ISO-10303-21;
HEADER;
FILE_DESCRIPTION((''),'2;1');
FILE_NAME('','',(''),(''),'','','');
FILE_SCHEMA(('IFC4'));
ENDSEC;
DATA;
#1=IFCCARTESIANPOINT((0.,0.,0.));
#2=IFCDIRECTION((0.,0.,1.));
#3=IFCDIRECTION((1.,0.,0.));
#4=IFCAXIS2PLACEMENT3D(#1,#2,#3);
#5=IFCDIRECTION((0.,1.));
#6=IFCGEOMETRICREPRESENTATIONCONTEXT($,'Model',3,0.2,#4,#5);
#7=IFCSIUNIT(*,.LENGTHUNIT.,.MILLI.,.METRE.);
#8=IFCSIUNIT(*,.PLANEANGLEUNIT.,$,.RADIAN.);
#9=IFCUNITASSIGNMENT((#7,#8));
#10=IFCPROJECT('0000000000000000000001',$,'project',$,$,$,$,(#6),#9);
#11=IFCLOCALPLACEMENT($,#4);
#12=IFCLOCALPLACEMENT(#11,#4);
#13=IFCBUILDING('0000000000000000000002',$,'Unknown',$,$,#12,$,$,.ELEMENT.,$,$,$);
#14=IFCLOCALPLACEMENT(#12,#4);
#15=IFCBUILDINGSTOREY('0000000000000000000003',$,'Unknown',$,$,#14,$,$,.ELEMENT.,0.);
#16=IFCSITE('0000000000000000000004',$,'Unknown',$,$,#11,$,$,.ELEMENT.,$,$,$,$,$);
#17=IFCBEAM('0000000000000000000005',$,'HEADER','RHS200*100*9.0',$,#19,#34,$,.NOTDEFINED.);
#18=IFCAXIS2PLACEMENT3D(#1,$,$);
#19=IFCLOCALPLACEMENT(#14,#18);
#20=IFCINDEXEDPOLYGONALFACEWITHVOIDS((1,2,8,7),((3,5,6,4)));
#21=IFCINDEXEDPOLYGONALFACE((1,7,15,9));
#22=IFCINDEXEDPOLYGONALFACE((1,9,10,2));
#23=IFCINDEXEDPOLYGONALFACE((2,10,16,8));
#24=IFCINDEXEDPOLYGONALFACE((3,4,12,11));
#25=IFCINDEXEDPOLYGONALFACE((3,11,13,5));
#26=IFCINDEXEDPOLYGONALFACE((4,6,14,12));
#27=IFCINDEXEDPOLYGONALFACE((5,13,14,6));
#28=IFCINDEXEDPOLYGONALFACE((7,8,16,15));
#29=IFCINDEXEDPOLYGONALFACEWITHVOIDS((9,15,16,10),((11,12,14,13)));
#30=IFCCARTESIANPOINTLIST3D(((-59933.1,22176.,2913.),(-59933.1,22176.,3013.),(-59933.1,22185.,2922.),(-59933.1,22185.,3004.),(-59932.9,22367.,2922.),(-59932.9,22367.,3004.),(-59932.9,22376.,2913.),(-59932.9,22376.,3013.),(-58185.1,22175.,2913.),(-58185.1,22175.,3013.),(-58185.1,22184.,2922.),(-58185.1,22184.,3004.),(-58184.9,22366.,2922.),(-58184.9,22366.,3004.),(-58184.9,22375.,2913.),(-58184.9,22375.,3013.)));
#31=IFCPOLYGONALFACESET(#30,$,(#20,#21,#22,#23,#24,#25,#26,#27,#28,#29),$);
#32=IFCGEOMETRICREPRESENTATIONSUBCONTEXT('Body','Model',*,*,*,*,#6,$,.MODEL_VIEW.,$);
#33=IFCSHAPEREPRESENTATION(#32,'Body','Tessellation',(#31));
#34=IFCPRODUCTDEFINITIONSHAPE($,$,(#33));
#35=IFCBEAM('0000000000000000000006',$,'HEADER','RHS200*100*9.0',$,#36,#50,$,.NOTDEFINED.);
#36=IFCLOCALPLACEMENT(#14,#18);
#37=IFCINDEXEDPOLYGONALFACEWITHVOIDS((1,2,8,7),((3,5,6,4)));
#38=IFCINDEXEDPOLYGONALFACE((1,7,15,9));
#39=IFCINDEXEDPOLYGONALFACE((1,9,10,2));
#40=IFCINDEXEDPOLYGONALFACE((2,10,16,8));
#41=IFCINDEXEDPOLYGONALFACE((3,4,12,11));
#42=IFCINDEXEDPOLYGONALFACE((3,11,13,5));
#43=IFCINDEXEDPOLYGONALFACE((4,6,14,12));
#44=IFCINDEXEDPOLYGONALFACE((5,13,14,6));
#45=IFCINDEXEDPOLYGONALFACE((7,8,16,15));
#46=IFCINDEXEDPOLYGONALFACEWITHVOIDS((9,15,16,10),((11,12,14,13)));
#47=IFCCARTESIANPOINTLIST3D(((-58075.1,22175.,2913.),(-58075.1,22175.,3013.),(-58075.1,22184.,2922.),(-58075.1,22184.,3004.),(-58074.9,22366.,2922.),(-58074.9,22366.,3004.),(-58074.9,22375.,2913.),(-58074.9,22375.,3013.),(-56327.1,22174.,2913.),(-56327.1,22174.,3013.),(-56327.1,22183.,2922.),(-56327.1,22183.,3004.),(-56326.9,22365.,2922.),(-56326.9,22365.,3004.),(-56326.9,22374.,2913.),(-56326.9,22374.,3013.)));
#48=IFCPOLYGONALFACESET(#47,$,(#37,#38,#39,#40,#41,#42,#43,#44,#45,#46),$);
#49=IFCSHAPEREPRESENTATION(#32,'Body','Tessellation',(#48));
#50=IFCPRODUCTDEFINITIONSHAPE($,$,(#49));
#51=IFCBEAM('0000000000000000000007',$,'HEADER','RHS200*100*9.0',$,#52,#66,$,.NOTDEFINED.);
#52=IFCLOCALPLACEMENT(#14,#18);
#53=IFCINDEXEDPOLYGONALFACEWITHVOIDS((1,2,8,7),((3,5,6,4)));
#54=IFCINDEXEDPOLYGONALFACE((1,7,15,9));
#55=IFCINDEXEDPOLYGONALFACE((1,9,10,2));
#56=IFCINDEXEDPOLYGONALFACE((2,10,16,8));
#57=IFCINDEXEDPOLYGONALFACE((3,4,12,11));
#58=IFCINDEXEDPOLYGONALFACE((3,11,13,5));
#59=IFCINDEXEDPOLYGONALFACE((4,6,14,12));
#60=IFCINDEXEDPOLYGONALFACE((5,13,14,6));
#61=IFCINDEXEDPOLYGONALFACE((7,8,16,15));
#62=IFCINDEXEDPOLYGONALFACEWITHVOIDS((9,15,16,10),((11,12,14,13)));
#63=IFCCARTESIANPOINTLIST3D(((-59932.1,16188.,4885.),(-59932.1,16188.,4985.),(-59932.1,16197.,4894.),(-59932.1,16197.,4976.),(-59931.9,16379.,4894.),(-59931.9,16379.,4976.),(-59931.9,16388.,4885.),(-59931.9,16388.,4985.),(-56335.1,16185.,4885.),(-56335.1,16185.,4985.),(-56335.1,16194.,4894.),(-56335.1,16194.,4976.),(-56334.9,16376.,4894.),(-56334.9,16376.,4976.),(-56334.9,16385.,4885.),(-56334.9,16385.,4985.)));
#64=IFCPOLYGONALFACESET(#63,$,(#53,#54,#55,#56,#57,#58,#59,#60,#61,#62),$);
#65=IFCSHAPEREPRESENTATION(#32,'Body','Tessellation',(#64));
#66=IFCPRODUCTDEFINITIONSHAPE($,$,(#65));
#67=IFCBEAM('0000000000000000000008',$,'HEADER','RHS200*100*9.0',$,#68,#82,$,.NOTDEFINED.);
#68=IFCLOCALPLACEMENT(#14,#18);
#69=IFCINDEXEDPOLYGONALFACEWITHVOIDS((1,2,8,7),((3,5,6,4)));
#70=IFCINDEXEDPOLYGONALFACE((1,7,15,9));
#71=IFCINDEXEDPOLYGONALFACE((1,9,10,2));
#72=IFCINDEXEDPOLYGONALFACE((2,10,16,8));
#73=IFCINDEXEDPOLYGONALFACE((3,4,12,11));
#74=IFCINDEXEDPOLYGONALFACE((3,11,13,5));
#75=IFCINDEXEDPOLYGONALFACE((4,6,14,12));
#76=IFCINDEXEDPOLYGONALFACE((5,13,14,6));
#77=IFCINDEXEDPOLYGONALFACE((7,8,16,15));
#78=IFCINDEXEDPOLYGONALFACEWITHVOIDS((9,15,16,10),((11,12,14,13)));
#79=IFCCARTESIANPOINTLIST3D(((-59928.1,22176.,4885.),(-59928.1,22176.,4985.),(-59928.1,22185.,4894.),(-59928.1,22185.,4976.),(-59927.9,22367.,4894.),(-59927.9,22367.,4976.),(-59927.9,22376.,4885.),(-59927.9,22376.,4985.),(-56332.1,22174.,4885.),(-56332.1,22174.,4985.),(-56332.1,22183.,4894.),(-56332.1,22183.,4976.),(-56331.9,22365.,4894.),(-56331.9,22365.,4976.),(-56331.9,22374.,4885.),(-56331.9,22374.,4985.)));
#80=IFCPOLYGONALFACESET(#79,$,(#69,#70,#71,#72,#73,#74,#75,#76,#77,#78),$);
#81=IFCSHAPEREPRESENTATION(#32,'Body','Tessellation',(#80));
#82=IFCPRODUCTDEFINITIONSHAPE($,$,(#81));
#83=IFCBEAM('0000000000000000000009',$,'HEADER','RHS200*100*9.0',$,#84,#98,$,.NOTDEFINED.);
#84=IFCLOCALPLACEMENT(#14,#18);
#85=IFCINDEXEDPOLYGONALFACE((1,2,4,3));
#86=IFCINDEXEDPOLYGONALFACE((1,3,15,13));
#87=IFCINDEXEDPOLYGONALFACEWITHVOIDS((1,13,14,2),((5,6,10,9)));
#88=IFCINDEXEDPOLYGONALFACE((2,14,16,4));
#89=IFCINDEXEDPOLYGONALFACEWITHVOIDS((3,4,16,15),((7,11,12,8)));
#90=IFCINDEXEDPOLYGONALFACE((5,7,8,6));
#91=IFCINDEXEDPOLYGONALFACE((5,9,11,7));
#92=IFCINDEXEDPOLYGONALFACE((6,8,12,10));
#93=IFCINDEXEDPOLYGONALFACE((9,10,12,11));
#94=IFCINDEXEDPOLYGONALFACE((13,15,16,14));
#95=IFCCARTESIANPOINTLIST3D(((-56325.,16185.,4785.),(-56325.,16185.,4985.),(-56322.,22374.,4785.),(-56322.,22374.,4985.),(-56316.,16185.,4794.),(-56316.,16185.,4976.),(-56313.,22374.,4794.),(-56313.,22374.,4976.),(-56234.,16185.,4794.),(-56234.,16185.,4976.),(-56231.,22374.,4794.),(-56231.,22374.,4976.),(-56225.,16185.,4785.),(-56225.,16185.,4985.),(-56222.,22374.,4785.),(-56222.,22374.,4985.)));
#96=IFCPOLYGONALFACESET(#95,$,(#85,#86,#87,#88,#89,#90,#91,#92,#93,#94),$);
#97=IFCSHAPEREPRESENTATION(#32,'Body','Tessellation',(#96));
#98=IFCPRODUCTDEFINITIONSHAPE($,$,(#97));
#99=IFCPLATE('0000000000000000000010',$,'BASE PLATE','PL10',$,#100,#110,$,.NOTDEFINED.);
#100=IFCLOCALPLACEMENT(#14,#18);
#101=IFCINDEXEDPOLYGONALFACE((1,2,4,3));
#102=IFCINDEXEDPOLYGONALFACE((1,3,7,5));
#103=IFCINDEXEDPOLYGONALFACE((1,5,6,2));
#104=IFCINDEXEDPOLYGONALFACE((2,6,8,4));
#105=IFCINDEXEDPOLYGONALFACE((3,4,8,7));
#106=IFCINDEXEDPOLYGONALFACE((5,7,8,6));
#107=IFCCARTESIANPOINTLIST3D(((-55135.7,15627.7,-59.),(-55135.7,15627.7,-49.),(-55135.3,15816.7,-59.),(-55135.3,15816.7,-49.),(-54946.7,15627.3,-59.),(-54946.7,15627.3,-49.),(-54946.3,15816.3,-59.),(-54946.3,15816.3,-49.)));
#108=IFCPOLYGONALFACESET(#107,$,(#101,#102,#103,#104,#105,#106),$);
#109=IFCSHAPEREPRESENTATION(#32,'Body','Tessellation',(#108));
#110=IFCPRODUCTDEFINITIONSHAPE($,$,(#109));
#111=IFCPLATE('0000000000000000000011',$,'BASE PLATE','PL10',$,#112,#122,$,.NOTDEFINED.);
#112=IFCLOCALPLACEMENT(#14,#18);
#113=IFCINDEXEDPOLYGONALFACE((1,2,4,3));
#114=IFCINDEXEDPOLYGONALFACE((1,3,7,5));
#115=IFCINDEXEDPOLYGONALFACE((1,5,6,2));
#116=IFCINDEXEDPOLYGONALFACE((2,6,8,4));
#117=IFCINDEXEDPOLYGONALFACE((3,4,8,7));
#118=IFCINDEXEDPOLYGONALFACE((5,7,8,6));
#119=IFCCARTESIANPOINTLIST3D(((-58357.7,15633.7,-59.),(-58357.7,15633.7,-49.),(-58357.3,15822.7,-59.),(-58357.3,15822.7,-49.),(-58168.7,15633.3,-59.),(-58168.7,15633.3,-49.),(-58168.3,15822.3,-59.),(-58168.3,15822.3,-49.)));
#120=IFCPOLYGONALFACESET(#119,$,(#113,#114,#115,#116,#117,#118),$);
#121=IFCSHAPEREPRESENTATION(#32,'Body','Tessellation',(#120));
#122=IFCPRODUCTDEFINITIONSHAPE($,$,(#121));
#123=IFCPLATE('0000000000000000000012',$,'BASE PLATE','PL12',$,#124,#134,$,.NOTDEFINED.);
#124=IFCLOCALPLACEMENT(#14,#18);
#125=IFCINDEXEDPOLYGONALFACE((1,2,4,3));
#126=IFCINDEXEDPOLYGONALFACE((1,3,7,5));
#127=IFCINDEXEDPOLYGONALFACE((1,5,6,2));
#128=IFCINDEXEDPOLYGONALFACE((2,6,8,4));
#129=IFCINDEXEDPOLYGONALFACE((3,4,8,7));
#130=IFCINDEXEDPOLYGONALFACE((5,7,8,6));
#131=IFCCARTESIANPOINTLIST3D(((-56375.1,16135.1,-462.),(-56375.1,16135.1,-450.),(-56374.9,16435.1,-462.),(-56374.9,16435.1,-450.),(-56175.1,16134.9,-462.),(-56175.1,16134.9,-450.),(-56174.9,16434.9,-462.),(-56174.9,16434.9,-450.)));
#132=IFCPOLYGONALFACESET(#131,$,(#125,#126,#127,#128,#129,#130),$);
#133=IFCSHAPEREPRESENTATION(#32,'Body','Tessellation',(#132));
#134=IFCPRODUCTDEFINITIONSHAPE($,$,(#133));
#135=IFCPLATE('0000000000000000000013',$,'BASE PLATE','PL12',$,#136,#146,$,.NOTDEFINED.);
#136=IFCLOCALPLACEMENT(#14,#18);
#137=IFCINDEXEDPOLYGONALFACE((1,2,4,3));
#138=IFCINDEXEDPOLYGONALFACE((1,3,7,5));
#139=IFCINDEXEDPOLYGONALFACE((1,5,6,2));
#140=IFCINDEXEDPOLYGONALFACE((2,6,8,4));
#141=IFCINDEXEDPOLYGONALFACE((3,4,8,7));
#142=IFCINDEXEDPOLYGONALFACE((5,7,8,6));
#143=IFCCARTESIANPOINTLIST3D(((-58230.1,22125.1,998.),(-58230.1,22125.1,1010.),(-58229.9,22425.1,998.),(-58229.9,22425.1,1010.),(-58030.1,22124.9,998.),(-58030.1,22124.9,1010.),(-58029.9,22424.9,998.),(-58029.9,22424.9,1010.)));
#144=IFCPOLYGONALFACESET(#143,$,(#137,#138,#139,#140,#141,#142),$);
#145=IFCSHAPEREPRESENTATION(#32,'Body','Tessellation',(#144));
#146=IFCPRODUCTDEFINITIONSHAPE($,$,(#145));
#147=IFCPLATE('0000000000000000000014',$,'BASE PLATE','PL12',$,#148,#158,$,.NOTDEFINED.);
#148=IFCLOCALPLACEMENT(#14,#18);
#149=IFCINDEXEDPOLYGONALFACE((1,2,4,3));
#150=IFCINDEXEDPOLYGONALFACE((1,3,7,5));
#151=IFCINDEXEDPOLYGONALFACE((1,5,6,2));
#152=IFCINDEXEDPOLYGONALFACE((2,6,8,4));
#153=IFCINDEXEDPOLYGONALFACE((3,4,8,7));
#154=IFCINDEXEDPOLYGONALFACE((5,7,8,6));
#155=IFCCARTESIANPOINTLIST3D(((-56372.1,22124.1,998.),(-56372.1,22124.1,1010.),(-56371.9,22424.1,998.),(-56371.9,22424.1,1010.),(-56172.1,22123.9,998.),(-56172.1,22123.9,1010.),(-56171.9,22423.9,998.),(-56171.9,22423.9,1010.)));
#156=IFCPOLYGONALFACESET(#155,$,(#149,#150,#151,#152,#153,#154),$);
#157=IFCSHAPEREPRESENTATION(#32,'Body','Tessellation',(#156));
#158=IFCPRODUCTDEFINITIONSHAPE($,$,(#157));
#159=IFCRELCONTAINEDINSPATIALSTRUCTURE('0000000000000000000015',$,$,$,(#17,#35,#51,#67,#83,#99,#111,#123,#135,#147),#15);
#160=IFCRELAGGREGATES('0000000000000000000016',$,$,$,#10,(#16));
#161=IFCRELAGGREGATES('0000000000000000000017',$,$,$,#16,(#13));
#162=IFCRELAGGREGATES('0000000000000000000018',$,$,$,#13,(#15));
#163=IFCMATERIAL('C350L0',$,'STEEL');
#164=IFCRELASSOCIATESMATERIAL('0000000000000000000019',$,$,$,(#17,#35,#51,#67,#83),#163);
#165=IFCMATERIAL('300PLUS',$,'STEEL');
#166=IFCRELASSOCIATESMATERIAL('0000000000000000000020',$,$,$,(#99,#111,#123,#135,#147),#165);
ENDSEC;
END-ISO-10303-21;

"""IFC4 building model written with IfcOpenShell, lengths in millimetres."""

from ifc_helpers import new_model, si_unit, direction, frame, origin_with_axes, place, context, subcontext, project, spatial, line, indexed_curve, outline, extrude, material, element, save


model = new_model("IFC4")

# Units and contexts
model_context = context("Model", 3, precision=0.2, world=origin_with_axes(), true_north=direction((0.0, 1.0)))
body_context = subcontext(model_context, "Body", "Model", "MODEL_VIEW")
ifc_project = project(units=[si_unit("LENGTHUNIT", "METRE", prefix="MILLI"), si_unit("PLANEANGLEUNIT", "RADIAN")], contexts=[model_context])

# Site, building, storey
site_placement = place(None, origin_with_axes())
site = spatial("IfcSite", under=ifc_project, at=site_placement, Name="Unknown", CompositionType="ELEMENT")
building_placement = place(site_placement, origin_with_axes())
building = spatial("IfcBuilding", under=site, at=building_placement, Name="Unknown", CompositionType="ELEMENT")
storey_placement = place(building_placement, origin_with_axes())
storey = spatial("IfcBuildingStorey", under=building, at=storey_placement, Name="Unknown", CompositionType="ELEMENT", Elevation=0.0)

# Shared definitions
ifc_material_1 = material(Name="C350L0", Category="STEEL")

# Beams
for number, where, z_axis, x_axis, name in (
    (1, (-58185.0, 22275.0, 2963.0), (0.0, 0.0, 1.0), (-1.0, 0.000572, 0.0), "HEADER"),
    (2, (-56327.0, 22274.0, 2963.0), (0.0, 0.0, 1.0), (-1.0, 0.000572, 0.0), "HEADER"),
):
    element("IfcBeam", number, at=place(storey_placement, frame(where, z_axis=z_axis, x_axis=x_axis)), inside=storey, material=ifc_material_1, Name=name, Description="RHS200*100*9.0", PredefinedType="NOTDEFINED", context=body_context, shape_type="SolidModel", body=[
        extrude(outline(indexed_curve([(-50.0, -100.0), (50.0, -100.0), (50.0, 100.0), (-50.0, 100.0)], segments=[line(1, 2, 3, 4, 1)]), holes=[indexed_curve([(-41.0, -91.0), (-41.0, 91.0), (41.0, 91.0), (41.0, -91.0)], segments=[line(1, 2, 3, 4, 1)])]), frame((0.0, 0.0, 0.0), z_axis=(-1.0, 0.0, 0.0), x_axis=(0.0, 0.0, 1.0)), (0.0, 0.0, -1.0), 1748.0),
    ])
beam_1_placement = place(storey_placement, frame((-56335.0, 16285.0, 4935.0), z_axis=(0.0, 0.0, 1.0), x_axis=(-1.0, 0.000834, 0.0)))
element("IfcBeam", 3, at=beam_1_placement, inside=storey, material=ifc_material_1, Name="HEADER", Description="RHS200*100*9.0", PredefinedType="NOTDEFINED", context=body_context, shape_type="SolidModel", body=[
    extrude(outline(indexed_curve([(-50.0, -100.0), (50.0, -100.0), (50.0, 100.0), (-50.0, 100.0)], segments=[line(1, 2, 3, 4, 1)]), holes=[indexed_curve([(-41.0, -91.0), (-41.0, 91.0), (41.0, 91.0), (41.0, -91.0)], segments=[line(1, 2, 3, 4, 1)])]), frame((0.0, 0.0, 0.0), z_axis=(-1.0, 0.0, 0.0), x_axis=(0.0, 0.0, 1.0)), (0.0, 0.0, -1.0), 3597.0),
])
beam_2_placement = place(storey_placement, frame((-56332.0, 22274.0, 4935.0), z_axis=(0.0, 0.0, 1.0), x_axis=(-1.0, 0.000556, 0.0)))
element("IfcBeam", 4, at=beam_2_placement, inside=storey, material=ifc_material_1, Name="HEADER", Description="RHS200*100*9.0", PredefinedType="NOTDEFINED", context=body_context, shape_type="SolidModel", body=[
    extrude(outline(indexed_curve([(-50.0, -100.0), (50.0, -100.0), (50.0, 100.0), (-50.0, 100.0)], segments=[line(1, 2, 3, 4, 1)]), holes=[indexed_curve([(-41.0, -91.0), (-41.0, 91.0), (41.0, 91.0), (41.0, -91.0)], segments=[line(1, 2, 3, 4, 1)])]), frame((0.0, 0.0, 0.0), z_axis=(-1.0, 0.0, 0.0), x_axis=(0.0, 0.0, 1.0)), (0.0, 0.0, -1.0), 3596.0),
])
beam_3_placement = place(storey_placement, frame((-56275.0, 16185.0, 4885.0), z_axis=(1.0, -0.000485, 0.0), x_axis=(0.000485, 1.0, 0.0)))
element("IfcBeam", 5, at=beam_3_placement, inside=storey, material=ifc_material_1, Name="HEADER", Description="RHS200*100*9.0", PredefinedType="NOTDEFINED", context=body_context, shape_type="SolidModel", body=[
    extrude(outline(indexed_curve([(-50.0, -100.0), (50.0, -100.0), (50.0, 100.0), (-50.0, 100.0)], segments=[line(1, 2, 3, 4, 1)]), holes=[indexed_curve([(-41.0, -91.0), (-41.0, 91.0), (41.0, 91.0), (41.0, -91.0)], segments=[line(1, 2, 3, 4, 1)])]), frame((0.0, 0.0, 0.0), z_axis=(-1.0, 0.0, 0.0), x_axis=(0.0, 0.0, 1.0)), (0.0, 0.0, -1.0), 6189.0),
])

# Plates
ifc_material_2 = material(Name="300PLUS", Category="STEEL")
for number, where, z_axis, x_axis, name in (
    (6, (-55135.7, 15627.7, -54.0), (0.0, 0.0, 1.0), (0.999998, -0.002116, 0.0), "BASE PLATE"),
    (7, (-58357.7, 15633.7, -54.0), (0.0, 0.0, 1.0), (0.999998, -0.002116, 0.0), "BASE PLATE"),
):
    element("IfcPlate", number, at=place(storey_placement, frame(where, z_axis=z_axis, x_axis=x_axis)), inside=storey, material=ifc_material_2, Name=name, Description="PL10", PredefinedType="NOTDEFINED", context=body_context, shape_type="SolidModel", body=[
        extrude(outline(indexed_curve([(0.0, 0.0), (189.0, 0.0), (189.0, 189.0), (0.0, 189.0)], segments=[line(1, 2, 3, 4, 1)])), frame((0.0, 0.0, 5.0), z_axis=(0.0, 0.0, 1.0), x_axis=(1.0, 0.0, 0.0)), (0.0, 0.0, -1.0), 10.0),
    ])
for number, where, z_axis, x_axis, name in (
    (8, (-56374.9, 16435.1, -456.0), (0.0, 0.0, 1.0), (-0.000667, -1.0, 0.0), "BASE PLATE"),
    (9, (-58229.9, 22425.1, 1004.0), (0.0, 0.0, 1.0), (-0.000667, -1.0, 0.0), "BASE PLATE"),
    (10, (-56371.9, 22424.1, 1004.0), (0.0, 0.0, 1.0), (-0.000667, -1.0, 0.0), "BASE PLATE"),
):
    element("IfcPlate", number, at=place(storey_placement, frame(where, z_axis=z_axis, x_axis=x_axis)), inside=storey, material=ifc_material_2, Name=name, Description="PL12", PredefinedType="NOTDEFINED", context=body_context, shape_type="SolidModel", body=[
        extrude(outline(indexed_curve([(0.0, 0.0), (300.0, 0.0), (300.1, 200.0), (0.1, 200.0)], segments=[line(1, 2, 3, 4, 1)])), frame((0.0, 0.0, 6.0), z_axis=(0.0, 0.0, 1.0), x_axis=(1.0, 0.0, 0.0)), (0.0, 0.0, -1.0), 12.0),
    ])

save(model, "model.ifc")
